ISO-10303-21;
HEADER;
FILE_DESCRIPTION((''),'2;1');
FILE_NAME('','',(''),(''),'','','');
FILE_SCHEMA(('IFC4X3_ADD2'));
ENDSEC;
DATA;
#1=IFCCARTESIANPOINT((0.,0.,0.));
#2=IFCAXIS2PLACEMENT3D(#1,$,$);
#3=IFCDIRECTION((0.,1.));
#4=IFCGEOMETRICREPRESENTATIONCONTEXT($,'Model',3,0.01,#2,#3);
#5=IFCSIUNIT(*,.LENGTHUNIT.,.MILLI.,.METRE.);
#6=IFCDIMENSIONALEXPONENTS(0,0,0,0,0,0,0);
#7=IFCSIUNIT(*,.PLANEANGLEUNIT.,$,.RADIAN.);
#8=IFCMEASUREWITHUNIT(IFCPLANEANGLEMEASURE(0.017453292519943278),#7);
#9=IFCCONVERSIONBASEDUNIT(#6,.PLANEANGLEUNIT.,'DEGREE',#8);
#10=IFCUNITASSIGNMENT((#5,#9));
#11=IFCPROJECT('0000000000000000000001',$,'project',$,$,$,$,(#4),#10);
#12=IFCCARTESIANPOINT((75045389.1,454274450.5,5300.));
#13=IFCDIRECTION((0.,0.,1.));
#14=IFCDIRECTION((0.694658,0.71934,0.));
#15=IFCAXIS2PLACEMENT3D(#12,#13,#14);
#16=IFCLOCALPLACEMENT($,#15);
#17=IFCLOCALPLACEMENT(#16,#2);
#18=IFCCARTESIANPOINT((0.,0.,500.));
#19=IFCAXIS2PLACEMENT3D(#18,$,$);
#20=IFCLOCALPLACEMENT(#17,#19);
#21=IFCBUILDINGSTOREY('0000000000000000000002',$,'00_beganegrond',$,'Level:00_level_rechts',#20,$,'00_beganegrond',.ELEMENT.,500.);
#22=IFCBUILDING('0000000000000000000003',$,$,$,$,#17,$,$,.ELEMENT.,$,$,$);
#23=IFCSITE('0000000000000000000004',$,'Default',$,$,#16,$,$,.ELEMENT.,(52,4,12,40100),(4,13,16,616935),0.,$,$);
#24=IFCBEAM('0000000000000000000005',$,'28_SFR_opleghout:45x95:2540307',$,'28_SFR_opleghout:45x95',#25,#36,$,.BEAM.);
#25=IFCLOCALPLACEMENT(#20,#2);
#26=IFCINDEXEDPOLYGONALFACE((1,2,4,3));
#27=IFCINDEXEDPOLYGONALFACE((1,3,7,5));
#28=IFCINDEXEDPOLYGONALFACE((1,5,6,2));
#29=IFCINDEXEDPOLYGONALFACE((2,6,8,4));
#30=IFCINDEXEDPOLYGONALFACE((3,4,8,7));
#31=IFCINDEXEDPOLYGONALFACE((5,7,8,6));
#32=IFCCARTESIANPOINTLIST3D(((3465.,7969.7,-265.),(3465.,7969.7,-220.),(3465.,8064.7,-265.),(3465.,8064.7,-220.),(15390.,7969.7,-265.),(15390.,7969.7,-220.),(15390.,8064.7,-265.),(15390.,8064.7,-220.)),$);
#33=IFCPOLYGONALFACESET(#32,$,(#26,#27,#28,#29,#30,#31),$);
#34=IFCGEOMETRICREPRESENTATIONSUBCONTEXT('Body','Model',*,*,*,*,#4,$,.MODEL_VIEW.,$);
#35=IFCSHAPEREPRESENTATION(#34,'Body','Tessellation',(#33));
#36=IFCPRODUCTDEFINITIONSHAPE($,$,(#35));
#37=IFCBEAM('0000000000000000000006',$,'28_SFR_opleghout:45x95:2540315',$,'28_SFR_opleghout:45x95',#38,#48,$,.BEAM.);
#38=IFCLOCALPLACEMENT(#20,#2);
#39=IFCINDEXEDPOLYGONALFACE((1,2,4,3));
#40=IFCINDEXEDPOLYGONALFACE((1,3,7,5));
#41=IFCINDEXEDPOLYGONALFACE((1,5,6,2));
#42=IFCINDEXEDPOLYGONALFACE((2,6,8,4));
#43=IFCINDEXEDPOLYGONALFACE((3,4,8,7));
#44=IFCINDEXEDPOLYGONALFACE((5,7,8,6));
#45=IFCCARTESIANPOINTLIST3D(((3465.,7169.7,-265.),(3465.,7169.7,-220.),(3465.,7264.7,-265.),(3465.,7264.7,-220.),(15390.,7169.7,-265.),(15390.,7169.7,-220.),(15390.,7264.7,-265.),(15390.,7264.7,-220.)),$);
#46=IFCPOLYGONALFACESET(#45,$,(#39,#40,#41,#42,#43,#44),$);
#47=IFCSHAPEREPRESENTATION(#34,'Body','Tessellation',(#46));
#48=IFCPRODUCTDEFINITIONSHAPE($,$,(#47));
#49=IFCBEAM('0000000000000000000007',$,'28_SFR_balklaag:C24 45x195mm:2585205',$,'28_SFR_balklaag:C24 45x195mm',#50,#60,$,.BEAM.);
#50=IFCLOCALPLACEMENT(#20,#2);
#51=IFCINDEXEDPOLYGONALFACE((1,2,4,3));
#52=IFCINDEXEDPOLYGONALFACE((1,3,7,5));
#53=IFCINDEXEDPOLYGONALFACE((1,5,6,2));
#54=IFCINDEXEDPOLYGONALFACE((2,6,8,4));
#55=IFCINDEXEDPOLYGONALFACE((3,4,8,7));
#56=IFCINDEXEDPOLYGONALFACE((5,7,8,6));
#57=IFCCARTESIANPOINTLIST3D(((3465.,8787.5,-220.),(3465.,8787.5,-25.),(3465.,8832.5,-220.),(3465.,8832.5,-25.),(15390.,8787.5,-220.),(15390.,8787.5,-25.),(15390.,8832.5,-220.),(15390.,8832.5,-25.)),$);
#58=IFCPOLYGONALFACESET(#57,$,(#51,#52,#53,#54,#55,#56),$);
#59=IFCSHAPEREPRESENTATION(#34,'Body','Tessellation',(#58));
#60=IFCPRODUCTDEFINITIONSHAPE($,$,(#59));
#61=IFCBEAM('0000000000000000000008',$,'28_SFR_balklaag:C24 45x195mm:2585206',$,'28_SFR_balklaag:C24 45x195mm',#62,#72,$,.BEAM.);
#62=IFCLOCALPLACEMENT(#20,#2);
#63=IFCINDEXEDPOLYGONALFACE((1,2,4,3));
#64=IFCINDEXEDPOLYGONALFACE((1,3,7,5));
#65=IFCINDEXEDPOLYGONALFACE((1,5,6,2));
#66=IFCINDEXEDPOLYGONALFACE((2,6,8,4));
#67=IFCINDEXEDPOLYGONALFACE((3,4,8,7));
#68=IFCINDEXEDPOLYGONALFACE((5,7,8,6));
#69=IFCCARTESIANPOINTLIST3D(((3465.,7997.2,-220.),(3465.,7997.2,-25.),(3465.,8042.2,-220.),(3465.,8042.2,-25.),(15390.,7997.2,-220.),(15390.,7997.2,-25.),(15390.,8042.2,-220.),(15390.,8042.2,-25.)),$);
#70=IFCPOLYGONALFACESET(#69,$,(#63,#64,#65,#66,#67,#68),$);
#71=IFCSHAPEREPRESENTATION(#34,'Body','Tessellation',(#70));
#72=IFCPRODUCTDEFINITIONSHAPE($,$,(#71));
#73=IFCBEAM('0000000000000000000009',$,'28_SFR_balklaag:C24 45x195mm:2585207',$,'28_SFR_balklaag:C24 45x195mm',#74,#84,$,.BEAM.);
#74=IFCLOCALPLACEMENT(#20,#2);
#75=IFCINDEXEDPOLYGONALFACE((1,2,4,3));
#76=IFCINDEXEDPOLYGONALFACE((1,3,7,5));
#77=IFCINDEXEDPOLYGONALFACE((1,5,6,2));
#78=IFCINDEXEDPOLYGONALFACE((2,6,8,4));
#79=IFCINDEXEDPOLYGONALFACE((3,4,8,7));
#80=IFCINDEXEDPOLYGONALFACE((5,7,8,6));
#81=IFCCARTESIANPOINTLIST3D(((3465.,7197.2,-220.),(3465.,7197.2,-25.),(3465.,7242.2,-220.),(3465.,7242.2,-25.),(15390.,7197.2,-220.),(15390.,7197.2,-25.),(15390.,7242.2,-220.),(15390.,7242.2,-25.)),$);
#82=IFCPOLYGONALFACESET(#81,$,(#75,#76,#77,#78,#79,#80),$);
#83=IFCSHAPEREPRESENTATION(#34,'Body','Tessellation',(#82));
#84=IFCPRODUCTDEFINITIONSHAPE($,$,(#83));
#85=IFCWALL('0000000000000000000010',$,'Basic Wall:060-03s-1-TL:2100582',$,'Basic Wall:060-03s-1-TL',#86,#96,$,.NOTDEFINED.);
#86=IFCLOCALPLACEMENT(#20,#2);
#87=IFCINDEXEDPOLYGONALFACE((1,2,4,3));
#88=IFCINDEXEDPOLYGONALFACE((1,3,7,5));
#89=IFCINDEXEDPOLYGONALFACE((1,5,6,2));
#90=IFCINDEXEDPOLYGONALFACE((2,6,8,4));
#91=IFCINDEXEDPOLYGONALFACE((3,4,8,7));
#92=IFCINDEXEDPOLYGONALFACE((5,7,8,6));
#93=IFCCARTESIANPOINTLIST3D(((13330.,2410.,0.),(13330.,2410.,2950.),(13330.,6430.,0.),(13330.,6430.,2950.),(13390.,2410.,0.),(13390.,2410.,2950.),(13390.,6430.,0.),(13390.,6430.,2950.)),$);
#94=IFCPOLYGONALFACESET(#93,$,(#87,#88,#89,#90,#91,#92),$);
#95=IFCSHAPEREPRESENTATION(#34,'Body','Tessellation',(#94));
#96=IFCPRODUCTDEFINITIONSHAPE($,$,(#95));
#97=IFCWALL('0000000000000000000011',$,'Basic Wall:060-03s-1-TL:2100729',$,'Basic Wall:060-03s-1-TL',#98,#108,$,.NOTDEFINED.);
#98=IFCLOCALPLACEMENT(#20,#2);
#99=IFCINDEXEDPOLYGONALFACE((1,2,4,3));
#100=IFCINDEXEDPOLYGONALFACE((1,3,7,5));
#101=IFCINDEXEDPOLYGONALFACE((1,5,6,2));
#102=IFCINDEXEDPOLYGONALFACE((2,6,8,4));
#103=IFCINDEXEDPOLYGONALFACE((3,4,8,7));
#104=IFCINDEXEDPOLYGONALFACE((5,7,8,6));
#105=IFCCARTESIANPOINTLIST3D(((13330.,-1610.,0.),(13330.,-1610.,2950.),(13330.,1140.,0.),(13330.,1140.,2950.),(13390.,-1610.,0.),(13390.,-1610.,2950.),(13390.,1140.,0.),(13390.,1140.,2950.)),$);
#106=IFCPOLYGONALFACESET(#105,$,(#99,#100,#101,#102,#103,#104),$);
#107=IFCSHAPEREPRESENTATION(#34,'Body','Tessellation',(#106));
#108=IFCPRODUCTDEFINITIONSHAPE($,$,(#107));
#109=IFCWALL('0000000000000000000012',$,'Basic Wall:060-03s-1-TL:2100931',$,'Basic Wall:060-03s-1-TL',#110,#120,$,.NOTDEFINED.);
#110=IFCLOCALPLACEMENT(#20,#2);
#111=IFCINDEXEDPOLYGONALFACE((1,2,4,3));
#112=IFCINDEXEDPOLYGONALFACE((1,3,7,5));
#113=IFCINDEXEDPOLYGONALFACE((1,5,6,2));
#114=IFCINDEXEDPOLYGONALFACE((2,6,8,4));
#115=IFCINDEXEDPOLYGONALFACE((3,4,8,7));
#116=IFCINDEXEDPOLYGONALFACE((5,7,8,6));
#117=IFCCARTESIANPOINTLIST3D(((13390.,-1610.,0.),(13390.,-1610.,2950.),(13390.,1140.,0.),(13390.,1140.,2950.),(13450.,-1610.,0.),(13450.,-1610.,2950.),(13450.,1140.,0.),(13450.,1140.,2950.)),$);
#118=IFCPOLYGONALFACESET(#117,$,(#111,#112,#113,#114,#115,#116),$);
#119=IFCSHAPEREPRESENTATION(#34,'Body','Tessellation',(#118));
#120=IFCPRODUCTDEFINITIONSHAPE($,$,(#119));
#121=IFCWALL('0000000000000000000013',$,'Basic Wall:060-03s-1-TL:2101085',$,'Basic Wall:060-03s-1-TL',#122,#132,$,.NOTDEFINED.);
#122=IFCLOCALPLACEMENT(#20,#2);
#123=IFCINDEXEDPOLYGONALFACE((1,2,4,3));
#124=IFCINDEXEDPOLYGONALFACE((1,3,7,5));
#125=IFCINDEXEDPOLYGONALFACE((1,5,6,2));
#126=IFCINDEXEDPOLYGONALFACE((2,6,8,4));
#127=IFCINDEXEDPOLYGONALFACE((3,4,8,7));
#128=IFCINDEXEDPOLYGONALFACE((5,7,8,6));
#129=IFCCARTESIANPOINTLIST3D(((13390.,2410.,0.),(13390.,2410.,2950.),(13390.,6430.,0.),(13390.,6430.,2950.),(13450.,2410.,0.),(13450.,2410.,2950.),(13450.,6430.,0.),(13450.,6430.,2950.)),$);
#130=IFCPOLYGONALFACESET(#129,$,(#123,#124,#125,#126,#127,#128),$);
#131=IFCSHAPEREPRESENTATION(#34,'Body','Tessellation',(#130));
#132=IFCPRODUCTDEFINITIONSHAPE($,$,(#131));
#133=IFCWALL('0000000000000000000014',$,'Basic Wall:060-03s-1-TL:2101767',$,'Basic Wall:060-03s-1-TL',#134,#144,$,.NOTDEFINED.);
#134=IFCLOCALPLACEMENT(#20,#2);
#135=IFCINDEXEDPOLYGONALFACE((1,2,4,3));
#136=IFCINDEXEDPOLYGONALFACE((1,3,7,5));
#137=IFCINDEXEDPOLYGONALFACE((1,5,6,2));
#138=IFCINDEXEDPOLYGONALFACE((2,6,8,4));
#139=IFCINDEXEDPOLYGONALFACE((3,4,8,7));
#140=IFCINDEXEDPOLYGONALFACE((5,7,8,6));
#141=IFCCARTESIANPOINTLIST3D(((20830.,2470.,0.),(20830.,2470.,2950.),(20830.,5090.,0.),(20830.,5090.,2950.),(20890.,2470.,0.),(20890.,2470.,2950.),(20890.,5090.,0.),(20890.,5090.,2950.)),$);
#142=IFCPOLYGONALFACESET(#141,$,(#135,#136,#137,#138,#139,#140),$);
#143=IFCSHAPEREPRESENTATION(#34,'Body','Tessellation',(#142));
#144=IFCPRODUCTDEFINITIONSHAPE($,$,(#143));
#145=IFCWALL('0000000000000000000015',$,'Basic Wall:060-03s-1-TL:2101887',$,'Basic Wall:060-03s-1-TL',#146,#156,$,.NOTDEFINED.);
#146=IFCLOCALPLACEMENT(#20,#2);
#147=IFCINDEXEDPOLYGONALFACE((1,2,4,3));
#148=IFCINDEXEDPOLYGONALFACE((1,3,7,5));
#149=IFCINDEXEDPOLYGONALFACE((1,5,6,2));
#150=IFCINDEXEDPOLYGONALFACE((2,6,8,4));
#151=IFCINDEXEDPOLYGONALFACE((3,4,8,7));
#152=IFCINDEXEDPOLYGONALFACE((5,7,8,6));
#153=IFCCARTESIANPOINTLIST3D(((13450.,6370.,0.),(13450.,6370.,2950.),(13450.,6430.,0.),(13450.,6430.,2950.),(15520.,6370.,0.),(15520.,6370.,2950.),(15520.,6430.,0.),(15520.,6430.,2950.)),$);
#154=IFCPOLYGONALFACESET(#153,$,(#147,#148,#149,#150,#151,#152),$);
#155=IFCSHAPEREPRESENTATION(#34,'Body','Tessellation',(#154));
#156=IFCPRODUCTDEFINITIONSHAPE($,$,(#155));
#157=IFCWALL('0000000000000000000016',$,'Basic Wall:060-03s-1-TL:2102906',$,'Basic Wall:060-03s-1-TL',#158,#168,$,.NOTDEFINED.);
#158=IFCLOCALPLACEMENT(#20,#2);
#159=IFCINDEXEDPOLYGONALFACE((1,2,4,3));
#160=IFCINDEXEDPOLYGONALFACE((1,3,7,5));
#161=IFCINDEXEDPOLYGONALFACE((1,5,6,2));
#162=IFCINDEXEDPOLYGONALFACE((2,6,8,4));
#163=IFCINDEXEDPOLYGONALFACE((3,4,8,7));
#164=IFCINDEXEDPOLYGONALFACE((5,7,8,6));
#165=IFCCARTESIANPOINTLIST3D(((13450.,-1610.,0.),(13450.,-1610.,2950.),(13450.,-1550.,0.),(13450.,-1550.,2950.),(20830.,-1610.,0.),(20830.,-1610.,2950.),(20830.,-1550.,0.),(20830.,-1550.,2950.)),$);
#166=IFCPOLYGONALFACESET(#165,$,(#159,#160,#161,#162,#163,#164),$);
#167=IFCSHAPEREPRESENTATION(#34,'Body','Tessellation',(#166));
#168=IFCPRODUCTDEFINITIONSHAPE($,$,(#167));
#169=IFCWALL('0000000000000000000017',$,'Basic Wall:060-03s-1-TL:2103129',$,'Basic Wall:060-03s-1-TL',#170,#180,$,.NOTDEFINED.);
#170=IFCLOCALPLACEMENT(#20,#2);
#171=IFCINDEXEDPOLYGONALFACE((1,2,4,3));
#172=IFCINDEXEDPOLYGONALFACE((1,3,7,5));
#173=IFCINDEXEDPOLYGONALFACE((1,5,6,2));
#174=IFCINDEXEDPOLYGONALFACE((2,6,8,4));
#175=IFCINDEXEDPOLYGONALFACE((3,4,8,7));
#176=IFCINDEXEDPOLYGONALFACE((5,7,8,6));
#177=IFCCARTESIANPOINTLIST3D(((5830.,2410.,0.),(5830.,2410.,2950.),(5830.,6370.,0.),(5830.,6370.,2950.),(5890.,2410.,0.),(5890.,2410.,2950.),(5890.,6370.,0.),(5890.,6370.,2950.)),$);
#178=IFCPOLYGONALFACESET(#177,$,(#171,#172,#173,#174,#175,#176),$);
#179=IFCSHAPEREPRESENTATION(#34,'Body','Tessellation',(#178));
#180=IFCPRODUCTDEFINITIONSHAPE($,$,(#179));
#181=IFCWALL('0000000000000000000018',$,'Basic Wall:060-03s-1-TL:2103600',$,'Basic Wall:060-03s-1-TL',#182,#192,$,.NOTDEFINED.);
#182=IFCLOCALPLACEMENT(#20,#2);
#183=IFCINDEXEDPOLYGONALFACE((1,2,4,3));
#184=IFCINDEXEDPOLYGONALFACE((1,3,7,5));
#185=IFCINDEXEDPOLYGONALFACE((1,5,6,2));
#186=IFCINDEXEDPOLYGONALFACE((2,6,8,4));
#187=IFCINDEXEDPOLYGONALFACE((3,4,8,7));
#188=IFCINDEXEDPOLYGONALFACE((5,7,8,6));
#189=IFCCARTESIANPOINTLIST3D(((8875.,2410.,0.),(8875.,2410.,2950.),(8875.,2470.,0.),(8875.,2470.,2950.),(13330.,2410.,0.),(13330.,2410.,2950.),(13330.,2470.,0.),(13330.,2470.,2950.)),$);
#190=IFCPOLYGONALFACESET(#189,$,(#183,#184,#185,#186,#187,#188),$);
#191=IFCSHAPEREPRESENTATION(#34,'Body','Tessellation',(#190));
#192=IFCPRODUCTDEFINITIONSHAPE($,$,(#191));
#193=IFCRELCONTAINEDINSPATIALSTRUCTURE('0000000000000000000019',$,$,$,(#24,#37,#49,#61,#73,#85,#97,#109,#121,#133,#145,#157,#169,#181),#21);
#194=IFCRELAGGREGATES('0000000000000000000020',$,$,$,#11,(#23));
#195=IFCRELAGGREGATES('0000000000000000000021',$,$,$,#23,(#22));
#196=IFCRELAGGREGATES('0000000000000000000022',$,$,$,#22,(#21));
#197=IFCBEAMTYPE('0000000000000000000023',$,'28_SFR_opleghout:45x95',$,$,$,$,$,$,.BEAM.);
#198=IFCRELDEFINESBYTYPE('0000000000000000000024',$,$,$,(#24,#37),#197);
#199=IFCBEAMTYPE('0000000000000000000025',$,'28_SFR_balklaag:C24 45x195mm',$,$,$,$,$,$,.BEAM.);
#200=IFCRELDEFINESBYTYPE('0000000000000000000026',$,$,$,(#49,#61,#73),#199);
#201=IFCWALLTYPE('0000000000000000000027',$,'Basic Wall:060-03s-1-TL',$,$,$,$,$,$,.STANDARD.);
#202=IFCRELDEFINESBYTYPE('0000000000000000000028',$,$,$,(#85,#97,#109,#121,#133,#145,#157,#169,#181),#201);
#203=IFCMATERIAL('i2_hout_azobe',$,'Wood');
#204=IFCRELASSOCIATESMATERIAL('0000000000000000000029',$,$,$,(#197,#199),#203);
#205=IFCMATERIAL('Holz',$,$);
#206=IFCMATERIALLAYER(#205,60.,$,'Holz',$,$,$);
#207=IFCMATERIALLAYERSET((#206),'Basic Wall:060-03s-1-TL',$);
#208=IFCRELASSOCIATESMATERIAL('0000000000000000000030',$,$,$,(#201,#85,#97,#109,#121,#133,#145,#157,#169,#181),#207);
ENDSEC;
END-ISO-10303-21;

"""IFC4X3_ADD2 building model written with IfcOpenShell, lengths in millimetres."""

from ifc_helpers import new_model, entity, si_unit, converted_unit, direction, frame, frame_2d, origin, origin_2d_with_axis, place, context, subcontext, project, spatial, rectangle, extrude, source, transform, mapped, material, layer, layer_set, material_profile, profile_set, type_object, type_shapes, element, save


model = new_model("IFC4X3_ADD2")

# Units and contexts
model_context = context("Model", 3, precision=0.01, world=origin(), true_north=direction((0.0, 1.0)))
body_context = subcontext(model_context, "Body", "Model", "MODEL_VIEW")
ifc_project = project(units=[si_unit("LENGTHUNIT", "METRE", prefix="MILLI"), converted_unit("PLANEANGLEUNIT", "DEGREE", entity("IfcPlaneAngleMeasure", 0.017453292519943278), si_unit("PLANEANGLEUNIT", "RADIAN"), dimensions=[0, 0, 0, 0, 0, 0, 0])], contexts=[model_context])

# Site, building, storey
site_placement = place(None, frame((75045389.1, 454274450.5, 5300.0), z_axis=(0.0, 0.0, 1.0), x_axis=(0.694658, 0.71934, 0.0)))
site = spatial("IfcSite", under=ifc_project, at=site_placement, Name="Default", CompositionType="ELEMENT", RefLatitude=(52, 4, 12, 40100), RefLongitude=(4, 13, 16, 616935), RefElevation=0.0)
building_placement = place(site_placement, origin())
building = spatial("IfcBuilding", under=site, at=building_placement, CompositionType="ELEMENT")
storey_placement = place(building_placement, frame((0.0, 0.0, 500.0)))
storey = spatial("IfcBuildingStorey", under=building, at=storey_placement, Name="00_beganegrond", ObjectType="Level:00_level_rechts", LongName="00_beganegrond", CompositionType="ELEMENT", Elevation=500.0)

# Beams
ifc_material_1 = material(Name="i2_hout_azobe", Category="Wood")
ifc_material_profile_1 = material_profile(ifc_material_1, rectangle(XDim=11925.0, YDim=95.0, at=frame_2d((0.0, 0.0), x_axis=(1.0, 0.0))), Name="45x95")
ifc_profile_set_1 = profile_set([ifc_material_profile_1], Name="45x95")
beam_type_1 = type_object("IfcBeamType", Name="28_SFR_opleghout:45x95", PredefinedType="BEAM", material=ifc_profile_set_1)
shared_shape_1 = source(origin(), body_context, "Body", "SweptSolid", [
    extrude(rectangle(XDim=11925.0, YDim=95.0, at=frame_2d((0.0, 0.0), x_axis=(1.0, 0.0))), frame((5962.5, 47.5, 0.0), z_axis=(0.0, 0.0, 1.0), x_axis=(-1.0, 0.0, 0.0)), (0.0, 0.0, 1.0), 45.0),
])
type_shapes(beam_type_1, [shared_shape_1])
for number, where, name in (
    (1, (3465.0, 7969.7, -265.0), "28_SFR_opleghout:45x95:2540307"),
    (2, (3465.0, 7169.7, -265.0), "28_SFR_opleghout:45x95:2540315"),
):
    element("IfcBeam", number, at=place(storey_placement, frame(where)), inside=storey, type_object=beam_type_1, Name=name, ObjectType="28_SFR_opleghout:45x95", PredefinedType="BEAM", context=body_context, shape_type="MappedRepresentation", body=[
        mapped(shared_shape_1, transform((0.0, 0.0, 0.0), scale=1.0)),
    ])
ifc_material_profile_2 = material_profile(ifc_material_1, rectangle(XDim=11925.0, YDim=45.0, at=origin_2d_with_axis()), Name="C24 45x195mm")
ifc_profile_set_2 = profile_set([ifc_material_profile_2], Name="C24 45x195mm")
beam_type_2 = type_object("IfcBeamType", Name="28_SFR_balklaag:C24 45x195mm", PredefinedType="BEAM", material=ifc_profile_set_2)
shared_shape_2 = source(origin(), body_context, "Body", "SweptSolid", [
    extrude(rectangle(XDim=11925.0, YDim=45.0, at=origin_2d_with_axis()), frame((5962.5, 22.5, 0.0), z_axis=(0.0, 0.0, 1.0), x_axis=(-1.0, 0.0, 0.0)), (0.0, 0.0, 1.0), 195.0),
])
type_shapes(beam_type_2, [shared_shape_2])
for number, where, name in (
    (3, (3465.0, 8787.5, -220.0), "28_SFR_balklaag:C24 45x195mm:2585205"),
    (4, (3465.0, 7997.2, -220.0), "28_SFR_balklaag:C24 45x195mm:2585206"),
    (5, (3465.0, 7197.2, -220.0), "28_SFR_balklaag:C24 45x195mm:2585207"),
):
    element("IfcBeam", number, at=place(storey_placement, frame(where)), inside=storey, type_object=beam_type_2, Name=name, ObjectType="28_SFR_balklaag:C24 45x195mm", PredefinedType="BEAM", context=body_context, shape_type="MappedRepresentation", body=[
        mapped(shared_shape_2, transform((0.0, 0.0, 0.0), scale=1.0)),
    ])

# Walls
ifc_material_2 = material(Name="Holz")
ifc_layer = layer(ifc_material_2, 60.0, Name="Holz")
ifc_layer_set = layer_set([ifc_layer], Name="Basic Wall:060-03s-1-TL")
wall_type = type_object("IfcWallType", Name="Basic Wall:060-03s-1-TL", PredefinedType="STANDARD", material=ifc_layer_set)
wall_1_placement = place(storey_placement, frame((13360.0, 6430.0, 0.0), z_axis=(0.0, 0.0, 1.0), x_axis=(0.0, -1.0, 0.0)))
element("IfcWall", 6, at=wall_1_placement, inside=storey, type_object=wall_type, material=ifc_layer_set, Name="Basic Wall:060-03s-1-TL:2100582", ObjectType="Basic Wall:060-03s-1-TL", PredefinedType="NOTDEFINED", context=body_context, shape_type="SweptSolid", body=[
    extrude(rectangle(XDim=4020.0, YDim=60.0, at=frame_2d((2010.0, 0.0), x_axis=(-1.0, 0.0))), origin(), (0.0, 0.0, 1.0), 2950.0),
])
wall_2_placement = place(storey_placement, frame((13360.0, 1140.0, 0.0), z_axis=(0.0, 0.0, 1.0), x_axis=(0.0, -1.0, 0.0)))
element("IfcWall", 7, at=wall_2_placement, inside=storey, type_object=wall_type, material=ifc_layer_set, Name="Basic Wall:060-03s-1-TL:2100729", ObjectType="Basic Wall:060-03s-1-TL", PredefinedType="NOTDEFINED", context=body_context, shape_type="SweptSolid", body=[
    extrude(rectangle(XDim=2750.0, YDim=60.0, at=frame_2d((1375.0, 0.0), x_axis=(-1.0, 0.0))), origin(), (0.0, 0.0, 1.0), 2950.0),
])
wall_3_placement = place(storey_placement, frame((13420.0, -1610.0, 0.0), z_axis=(0.0, 0.0, 1.0), x_axis=(0.0, 1.0, 0.0)))
element("IfcWall", 8, at=wall_3_placement, inside=storey, type_object=wall_type, material=ifc_layer_set, Name="Basic Wall:060-03s-1-TL:2100931", ObjectType="Basic Wall:060-03s-1-TL", PredefinedType="NOTDEFINED", context=body_context, shape_type="SweptSolid", body=[
    extrude(rectangle(XDim=2750.0, YDim=60.0, at=frame_2d((1375.0, 0.0), x_axis=(-1.0, 0.0))), origin(), (0.0, 0.0, 1.0), 2950.0),
])
wall_4_placement = place(storey_placement, frame((13420.0, 2410.0, 0.0), z_axis=(0.0, 0.0, 1.0), x_axis=(0.0, 1.0, 0.0)))
element("IfcWall", 9, at=wall_4_placement, inside=storey, type_object=wall_type, material=ifc_layer_set, Name="Basic Wall:060-03s-1-TL:2101085", ObjectType="Basic Wall:060-03s-1-TL", PredefinedType="NOTDEFINED", context=body_context, shape_type="SweptSolid", body=[
    extrude(rectangle(XDim=4020.0, YDim=60.0, at=frame_2d((2010.0, 0.0), x_axis=(-1.0, 0.0))), origin(), (0.0, 0.0, 1.0), 2950.0),
])
wall_5_placement = place(storey_placement, frame((20860.0, 2470.0, 0.0), z_axis=(0.0, 0.0, 1.0), x_axis=(0.0, 1.0, 0.0)))
element("IfcWall", 10, at=wall_5_placement, inside=storey, type_object=wall_type, material=ifc_layer_set, Name="Basic Wall:060-03s-1-TL:2101767", ObjectType="Basic Wall:060-03s-1-TL", PredefinedType="NOTDEFINED", context=body_context, shape_type="SweptSolid", body=[
    extrude(rectangle(XDim=2620.0, YDim=60.0, at=frame_2d((1310.0, 0.0), x_axis=(-1.0, 0.0))), origin(), (0.0, 0.0, 1.0), 2950.0),
])
wall_6_placement = place(storey_placement, frame((13450.0, 6400.0, 0.0)))
element("IfcWall", 11, at=wall_6_placement, inside=storey, type_object=wall_type, material=ifc_layer_set, Name="Basic Wall:060-03s-1-TL:2101887", ObjectType="Basic Wall:060-03s-1-TL", PredefinedType="NOTDEFINED", context=body_context, shape_type="SweptSolid", body=[
    extrude(rectangle(XDim=2070.0, YDim=60.0, at=frame_2d((1035.0, 0.0), x_axis=(-1.0, 0.0))), origin(), (0.0, 0.0, 1.0), 2950.0),
])
wall_7_placement = place(storey_placement, frame((13450.0, -1580.0, 0.0)))
element("IfcWall", 12, at=wall_7_placement, inside=storey, type_object=wall_type, material=ifc_layer_set, Name="Basic Wall:060-03s-1-TL:2102906", ObjectType="Basic Wall:060-03s-1-TL", PredefinedType="NOTDEFINED", context=body_context, shape_type="SweptSolid", body=[
    extrude(rectangle(XDim=7380.0, YDim=60.0, at=frame_2d((3690.0, 0.0), x_axis=(-1.0, 0.0))), origin(), (0.0, 0.0, 1.0), 2950.0),
])
wall_8_placement = place(storey_placement, frame((5860.0, 2410.0, 0.0), z_axis=(0.0, 0.0, 1.0), x_axis=(0.0, 1.0, 0.0)))
element("IfcWall", 13, at=wall_8_placement, inside=storey, type_object=wall_type, material=ifc_layer_set, Name="Basic Wall:060-03s-1-TL:2103129", ObjectType="Basic Wall:060-03s-1-TL", PredefinedType="NOTDEFINED", context=body_context, shape_type="SweptSolid", body=[
    extrude(rectangle(XDim=3960.0, YDim=60.0, at=frame_2d((1980.0, 0.0), x_axis=(-1.0, 0.0))), origin(), (0.0, 0.0, 1.0), 2950.0),
])
wall_9_placement = place(storey_placement, frame((13330.0, 2440.0, 0.0), z_axis=(0.0, 0.0, 1.0), x_axis=(-1.0, 0.0, 0.0)))
element("IfcWall", 14, at=wall_9_placement, inside=storey, type_object=wall_type, material=ifc_layer_set, Name="Basic Wall:060-03s-1-TL:2103600", ObjectType="Basic Wall:060-03s-1-TL", PredefinedType="NOTDEFINED", context=body_context, shape_type="SweptSolid", body=[
    extrude(rectangle(XDim=4455.0, YDim=60.0, at=frame_2d((2227.5, 0.0), x_axis=(-1.0, 0.0))), origin(), (0.0, 0.0, 1.0), 2950.0),
])

save(model, "model.ifc")
